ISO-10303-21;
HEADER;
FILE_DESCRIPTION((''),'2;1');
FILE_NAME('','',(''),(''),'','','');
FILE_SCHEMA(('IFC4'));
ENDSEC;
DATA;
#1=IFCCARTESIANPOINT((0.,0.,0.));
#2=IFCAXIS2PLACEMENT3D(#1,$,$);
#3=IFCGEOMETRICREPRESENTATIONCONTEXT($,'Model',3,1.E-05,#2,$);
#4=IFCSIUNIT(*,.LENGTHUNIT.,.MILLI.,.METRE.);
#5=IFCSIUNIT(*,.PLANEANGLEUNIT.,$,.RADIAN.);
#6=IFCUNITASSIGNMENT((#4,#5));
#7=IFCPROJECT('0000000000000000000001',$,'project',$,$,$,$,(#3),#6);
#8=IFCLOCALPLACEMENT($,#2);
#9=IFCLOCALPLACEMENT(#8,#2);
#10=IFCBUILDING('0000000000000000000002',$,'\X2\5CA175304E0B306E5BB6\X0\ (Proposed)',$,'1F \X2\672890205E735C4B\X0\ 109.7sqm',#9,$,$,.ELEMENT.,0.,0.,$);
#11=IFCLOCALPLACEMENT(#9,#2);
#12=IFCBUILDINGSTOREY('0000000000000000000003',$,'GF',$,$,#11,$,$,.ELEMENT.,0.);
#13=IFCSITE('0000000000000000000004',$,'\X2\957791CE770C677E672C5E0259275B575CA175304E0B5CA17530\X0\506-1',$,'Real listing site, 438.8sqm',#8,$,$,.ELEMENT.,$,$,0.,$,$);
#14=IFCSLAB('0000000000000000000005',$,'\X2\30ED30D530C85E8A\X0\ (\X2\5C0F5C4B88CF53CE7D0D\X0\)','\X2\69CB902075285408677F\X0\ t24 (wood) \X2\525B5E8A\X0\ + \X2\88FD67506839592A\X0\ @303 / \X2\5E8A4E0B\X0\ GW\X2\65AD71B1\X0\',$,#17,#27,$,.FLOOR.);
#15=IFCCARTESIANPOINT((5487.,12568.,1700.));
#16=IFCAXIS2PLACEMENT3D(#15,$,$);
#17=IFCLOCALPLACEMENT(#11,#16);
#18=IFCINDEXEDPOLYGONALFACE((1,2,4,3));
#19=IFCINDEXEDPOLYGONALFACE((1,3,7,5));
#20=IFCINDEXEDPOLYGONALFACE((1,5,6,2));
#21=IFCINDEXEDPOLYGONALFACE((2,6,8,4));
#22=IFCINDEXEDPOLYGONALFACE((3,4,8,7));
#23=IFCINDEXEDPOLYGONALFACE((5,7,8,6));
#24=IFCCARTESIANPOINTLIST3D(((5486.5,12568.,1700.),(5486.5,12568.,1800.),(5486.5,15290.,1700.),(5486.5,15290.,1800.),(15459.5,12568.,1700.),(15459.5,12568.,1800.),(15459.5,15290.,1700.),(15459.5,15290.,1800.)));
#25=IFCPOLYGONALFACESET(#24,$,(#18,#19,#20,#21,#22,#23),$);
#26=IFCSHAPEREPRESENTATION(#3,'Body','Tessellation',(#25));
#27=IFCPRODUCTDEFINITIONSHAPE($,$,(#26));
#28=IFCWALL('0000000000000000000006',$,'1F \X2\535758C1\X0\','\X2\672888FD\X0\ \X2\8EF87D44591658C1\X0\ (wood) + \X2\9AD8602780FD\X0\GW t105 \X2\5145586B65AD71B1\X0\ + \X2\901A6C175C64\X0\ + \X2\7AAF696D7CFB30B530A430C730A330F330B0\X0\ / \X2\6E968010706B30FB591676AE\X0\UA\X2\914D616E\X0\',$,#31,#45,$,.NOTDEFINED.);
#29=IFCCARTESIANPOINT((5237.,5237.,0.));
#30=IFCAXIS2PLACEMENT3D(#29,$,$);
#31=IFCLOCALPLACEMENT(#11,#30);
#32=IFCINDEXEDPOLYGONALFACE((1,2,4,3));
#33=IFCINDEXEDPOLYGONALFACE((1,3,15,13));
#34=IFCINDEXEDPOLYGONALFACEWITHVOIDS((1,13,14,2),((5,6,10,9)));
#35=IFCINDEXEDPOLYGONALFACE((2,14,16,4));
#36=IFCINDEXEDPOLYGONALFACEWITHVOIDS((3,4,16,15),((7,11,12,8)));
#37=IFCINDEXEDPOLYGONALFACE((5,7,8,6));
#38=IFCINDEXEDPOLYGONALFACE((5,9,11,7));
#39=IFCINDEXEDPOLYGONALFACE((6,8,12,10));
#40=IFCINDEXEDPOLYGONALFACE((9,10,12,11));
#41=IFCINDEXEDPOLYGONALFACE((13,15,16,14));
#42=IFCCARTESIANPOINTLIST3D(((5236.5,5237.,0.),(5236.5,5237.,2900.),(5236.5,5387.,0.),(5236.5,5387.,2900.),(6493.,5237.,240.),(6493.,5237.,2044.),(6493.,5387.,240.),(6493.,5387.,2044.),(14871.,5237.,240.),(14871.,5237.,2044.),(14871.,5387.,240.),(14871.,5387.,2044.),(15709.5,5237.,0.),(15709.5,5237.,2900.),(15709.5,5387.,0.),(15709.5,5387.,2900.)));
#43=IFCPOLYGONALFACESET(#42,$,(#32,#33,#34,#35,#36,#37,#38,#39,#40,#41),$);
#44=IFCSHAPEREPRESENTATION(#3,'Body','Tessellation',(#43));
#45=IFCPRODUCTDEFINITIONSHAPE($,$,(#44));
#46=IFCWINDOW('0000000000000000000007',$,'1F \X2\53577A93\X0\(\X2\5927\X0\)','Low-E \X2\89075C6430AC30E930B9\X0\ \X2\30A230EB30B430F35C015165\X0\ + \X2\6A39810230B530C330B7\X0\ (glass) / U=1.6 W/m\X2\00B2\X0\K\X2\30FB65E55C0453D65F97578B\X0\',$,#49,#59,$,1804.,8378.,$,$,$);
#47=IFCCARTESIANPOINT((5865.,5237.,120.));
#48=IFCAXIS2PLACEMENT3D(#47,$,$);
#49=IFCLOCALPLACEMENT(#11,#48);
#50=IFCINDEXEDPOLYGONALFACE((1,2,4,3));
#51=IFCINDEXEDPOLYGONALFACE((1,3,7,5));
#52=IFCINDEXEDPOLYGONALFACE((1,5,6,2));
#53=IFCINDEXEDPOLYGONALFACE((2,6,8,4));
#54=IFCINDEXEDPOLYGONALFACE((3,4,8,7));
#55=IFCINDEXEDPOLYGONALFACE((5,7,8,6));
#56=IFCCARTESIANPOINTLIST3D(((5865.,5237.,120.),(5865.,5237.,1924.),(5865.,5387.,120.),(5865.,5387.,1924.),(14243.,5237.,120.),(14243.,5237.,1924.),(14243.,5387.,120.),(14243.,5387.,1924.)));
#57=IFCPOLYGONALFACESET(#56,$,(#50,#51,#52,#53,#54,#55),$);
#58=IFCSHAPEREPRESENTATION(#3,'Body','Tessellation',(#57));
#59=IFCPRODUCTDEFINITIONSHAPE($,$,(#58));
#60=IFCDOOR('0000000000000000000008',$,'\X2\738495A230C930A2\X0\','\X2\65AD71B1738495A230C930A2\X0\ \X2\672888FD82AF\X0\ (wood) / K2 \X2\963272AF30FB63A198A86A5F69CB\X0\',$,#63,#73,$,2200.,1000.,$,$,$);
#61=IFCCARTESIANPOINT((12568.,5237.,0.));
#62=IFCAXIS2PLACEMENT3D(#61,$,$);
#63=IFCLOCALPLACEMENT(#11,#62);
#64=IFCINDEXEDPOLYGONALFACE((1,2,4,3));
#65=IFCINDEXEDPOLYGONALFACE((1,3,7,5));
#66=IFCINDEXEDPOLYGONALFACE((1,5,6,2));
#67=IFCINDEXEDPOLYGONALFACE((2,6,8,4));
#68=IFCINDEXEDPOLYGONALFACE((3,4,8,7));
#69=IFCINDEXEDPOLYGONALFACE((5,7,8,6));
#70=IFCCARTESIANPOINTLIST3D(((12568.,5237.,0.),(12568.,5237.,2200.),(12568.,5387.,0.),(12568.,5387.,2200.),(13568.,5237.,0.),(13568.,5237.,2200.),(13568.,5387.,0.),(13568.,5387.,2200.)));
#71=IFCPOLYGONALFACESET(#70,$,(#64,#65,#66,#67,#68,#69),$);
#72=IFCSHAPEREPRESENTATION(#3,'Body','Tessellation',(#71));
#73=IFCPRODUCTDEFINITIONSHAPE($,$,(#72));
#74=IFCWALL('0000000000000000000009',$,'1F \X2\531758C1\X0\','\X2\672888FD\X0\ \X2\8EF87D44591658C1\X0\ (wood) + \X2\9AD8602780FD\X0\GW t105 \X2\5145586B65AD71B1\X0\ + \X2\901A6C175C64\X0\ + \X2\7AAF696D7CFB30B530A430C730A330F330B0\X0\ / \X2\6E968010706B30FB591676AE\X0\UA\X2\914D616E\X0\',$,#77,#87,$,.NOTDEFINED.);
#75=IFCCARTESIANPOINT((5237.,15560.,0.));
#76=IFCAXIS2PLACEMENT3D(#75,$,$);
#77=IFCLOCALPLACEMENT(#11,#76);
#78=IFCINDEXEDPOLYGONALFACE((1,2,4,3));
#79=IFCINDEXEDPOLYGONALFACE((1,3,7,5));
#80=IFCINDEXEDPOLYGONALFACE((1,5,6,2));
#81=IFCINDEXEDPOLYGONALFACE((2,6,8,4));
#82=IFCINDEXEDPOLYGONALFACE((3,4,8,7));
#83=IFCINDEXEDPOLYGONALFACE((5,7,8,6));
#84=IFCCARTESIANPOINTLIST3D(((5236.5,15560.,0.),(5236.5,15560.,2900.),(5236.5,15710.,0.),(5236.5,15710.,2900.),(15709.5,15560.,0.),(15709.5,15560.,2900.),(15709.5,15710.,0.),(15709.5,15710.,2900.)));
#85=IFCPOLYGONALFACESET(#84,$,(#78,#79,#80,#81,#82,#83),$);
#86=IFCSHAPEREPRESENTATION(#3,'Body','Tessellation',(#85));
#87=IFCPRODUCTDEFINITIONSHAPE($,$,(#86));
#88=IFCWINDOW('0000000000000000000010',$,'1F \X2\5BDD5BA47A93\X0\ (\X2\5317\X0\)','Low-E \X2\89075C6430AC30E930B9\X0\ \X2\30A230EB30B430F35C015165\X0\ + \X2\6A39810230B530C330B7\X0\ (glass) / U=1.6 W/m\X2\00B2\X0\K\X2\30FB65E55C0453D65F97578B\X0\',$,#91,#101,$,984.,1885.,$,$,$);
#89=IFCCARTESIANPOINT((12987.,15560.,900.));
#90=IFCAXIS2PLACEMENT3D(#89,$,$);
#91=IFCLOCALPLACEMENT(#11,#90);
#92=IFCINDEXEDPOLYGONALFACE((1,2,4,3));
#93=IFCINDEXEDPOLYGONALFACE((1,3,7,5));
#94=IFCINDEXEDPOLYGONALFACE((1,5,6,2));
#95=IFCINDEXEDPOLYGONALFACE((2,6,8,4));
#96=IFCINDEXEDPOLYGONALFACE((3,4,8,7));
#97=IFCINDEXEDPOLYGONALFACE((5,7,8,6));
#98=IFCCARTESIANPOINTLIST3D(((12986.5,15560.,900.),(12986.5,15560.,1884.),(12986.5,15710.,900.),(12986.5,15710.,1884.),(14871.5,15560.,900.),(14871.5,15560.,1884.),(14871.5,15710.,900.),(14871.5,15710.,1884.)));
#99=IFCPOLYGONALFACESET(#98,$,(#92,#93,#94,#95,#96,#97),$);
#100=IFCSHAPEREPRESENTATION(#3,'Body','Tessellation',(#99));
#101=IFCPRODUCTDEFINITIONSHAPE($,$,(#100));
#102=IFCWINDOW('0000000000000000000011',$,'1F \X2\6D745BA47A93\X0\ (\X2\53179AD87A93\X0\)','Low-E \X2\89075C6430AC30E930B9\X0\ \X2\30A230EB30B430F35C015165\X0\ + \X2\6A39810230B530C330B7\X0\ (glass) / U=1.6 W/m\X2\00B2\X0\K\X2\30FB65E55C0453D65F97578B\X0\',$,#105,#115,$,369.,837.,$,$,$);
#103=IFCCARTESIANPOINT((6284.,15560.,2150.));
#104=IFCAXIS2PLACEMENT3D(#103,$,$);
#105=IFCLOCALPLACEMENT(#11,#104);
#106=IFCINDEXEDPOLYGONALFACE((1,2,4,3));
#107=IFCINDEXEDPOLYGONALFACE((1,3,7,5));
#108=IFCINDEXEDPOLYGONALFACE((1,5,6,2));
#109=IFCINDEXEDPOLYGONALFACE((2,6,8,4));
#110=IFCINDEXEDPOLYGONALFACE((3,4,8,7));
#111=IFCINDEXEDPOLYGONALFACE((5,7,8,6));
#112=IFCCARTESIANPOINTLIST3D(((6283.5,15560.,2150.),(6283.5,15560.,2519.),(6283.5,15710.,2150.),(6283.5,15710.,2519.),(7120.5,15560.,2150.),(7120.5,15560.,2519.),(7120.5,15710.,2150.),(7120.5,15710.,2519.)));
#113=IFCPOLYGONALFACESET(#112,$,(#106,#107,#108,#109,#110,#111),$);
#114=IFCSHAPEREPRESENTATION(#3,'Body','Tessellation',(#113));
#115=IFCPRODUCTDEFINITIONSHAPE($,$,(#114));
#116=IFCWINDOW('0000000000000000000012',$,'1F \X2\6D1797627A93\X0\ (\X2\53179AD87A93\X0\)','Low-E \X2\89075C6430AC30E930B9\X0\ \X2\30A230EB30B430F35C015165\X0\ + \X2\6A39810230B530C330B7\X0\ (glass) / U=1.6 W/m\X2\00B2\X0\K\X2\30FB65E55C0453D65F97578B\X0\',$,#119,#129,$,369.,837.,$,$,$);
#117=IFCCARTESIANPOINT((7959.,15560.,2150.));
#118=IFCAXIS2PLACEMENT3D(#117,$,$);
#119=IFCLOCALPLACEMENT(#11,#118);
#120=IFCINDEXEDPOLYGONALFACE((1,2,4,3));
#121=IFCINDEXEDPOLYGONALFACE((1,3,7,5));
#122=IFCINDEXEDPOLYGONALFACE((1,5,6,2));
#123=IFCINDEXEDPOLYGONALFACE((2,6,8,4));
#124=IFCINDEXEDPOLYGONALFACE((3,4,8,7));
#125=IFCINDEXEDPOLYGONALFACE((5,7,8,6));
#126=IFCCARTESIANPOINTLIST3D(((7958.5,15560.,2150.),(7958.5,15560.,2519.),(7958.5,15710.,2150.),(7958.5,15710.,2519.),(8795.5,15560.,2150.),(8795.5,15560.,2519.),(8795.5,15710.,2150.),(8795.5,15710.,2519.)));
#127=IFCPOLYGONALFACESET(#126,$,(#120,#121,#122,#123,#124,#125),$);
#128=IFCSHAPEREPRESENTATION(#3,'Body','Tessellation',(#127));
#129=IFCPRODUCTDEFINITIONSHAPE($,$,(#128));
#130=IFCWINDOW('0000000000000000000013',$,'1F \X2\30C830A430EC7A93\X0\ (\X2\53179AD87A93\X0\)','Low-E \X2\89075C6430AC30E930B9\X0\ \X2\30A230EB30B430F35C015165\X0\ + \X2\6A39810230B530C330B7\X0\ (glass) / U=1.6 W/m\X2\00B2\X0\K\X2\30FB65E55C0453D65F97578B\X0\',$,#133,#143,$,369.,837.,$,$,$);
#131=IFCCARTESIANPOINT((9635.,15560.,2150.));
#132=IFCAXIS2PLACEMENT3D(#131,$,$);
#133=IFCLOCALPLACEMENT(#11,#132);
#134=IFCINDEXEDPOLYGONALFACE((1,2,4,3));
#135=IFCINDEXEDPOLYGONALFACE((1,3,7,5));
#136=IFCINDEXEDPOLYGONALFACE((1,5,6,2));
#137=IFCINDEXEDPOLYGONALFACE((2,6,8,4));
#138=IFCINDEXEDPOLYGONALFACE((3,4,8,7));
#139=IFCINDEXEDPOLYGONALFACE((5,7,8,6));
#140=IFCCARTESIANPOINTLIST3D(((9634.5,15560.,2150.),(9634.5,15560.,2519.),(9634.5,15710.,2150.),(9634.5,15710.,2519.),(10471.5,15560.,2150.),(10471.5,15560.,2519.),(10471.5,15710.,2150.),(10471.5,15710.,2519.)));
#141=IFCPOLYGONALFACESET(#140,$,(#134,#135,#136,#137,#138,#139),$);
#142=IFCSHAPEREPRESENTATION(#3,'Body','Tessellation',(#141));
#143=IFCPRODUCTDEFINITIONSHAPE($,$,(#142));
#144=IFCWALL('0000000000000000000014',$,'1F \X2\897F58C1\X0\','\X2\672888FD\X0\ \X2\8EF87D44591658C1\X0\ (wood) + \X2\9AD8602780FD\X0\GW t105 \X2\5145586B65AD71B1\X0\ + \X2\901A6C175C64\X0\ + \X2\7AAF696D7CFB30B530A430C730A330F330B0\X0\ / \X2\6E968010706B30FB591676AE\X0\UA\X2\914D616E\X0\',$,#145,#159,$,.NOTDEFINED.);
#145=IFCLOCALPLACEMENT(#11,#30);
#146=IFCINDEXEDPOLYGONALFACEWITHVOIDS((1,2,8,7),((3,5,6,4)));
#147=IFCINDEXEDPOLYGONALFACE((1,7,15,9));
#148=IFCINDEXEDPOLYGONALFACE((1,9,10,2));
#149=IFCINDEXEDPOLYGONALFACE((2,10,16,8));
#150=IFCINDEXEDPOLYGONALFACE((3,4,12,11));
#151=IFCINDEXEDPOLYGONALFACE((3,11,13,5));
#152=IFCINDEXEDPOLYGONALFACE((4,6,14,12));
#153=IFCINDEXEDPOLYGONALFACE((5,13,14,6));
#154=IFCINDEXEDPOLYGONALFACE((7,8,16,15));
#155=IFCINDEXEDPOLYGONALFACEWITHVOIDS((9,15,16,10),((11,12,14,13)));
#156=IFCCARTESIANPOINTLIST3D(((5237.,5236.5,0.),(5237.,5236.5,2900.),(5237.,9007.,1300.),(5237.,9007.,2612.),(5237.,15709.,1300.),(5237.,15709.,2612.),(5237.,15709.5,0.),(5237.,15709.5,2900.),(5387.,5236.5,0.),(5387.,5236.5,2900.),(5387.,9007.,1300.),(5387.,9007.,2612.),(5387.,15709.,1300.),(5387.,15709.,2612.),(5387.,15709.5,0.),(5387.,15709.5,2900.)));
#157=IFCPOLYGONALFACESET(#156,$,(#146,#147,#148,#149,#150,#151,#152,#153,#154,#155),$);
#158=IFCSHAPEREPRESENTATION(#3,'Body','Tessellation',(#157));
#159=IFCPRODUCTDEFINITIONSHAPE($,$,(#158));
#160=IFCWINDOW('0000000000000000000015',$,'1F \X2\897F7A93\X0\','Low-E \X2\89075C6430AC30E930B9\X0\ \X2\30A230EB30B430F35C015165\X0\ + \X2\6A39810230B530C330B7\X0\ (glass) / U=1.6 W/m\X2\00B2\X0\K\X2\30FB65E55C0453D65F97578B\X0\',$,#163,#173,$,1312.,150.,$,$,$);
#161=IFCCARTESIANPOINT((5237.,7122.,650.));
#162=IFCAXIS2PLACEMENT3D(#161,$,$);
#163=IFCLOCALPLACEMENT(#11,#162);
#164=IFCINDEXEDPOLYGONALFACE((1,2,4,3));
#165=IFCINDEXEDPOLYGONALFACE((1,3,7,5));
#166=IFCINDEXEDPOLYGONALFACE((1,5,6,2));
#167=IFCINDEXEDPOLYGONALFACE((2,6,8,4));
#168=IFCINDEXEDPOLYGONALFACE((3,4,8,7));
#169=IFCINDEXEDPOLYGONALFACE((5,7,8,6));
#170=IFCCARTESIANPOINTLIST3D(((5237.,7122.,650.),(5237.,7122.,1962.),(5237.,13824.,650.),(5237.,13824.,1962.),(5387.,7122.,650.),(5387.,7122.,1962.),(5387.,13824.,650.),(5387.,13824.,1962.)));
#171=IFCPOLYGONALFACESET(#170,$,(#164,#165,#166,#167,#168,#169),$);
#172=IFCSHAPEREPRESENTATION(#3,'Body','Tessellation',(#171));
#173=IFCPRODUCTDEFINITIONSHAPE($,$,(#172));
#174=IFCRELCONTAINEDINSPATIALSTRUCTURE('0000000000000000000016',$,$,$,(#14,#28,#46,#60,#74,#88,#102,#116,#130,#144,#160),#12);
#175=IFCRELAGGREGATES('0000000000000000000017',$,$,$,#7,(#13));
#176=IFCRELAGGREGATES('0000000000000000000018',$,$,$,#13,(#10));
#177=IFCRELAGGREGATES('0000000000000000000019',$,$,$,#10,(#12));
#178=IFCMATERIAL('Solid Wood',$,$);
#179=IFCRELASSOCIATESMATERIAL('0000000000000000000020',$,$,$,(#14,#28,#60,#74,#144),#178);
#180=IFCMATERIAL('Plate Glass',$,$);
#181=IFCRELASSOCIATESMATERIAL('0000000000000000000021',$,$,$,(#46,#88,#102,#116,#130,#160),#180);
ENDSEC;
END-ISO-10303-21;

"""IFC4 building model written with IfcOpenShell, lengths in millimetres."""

from ifc_helpers import new_model, si_unit, frame, frame_2d, origin, place, context, project, spatial, rectangle, extrude, material, element, fill, save


model = new_model("IFC4")

# Units and contexts
model_context = context("Model", 3, precision=1e-05, world=origin())
ifc_project = project(units=[si_unit("LENGTHUNIT", "METRE", prefix="MILLI"), si_unit("PLANEANGLEUNIT", "RADIAN")], contexts=[model_context])

# Site, building, storey
site_placement = place(None, origin())
site = spatial("IfcSite", under=ifc_project, at=site_placement, Name="長野県松本市大字岡田下岡田506-1", ObjectType="Real listing site, 438.8sqm", CompositionType="ELEMENT", RefElevation=0.0)
building_placement = place(site_placement, origin())
building = spatial("IfcBuilding", under=site, at=building_placement, Name="岡田下の家 (Proposed)", ObjectType="1F 木造平屋 109.7sqm", CompositionType="ELEMENT", ElevationOfRefHeight=0.0, ElevationOfTerrain=0.0)
storey_placement = place(building_placement, origin())
storey = spatial("IfcBuildingStorey", under=building, at=storey_placement, Name="GF", CompositionType="ELEMENT", Elevation=0.0)

# Slab
ifc_material_1 = material(Name="Solid Wood")
slab_1_placement = place(storey_placement, frame((5487.0, 12568.0, 1700.0)))
element("IfcSlab", 1, at=slab_1_placement, inside=storey, material=ifc_material_1, Name="ロフト床 (小屋裏収納)", Description="構造用合板 t24 (wood) 剛床 + 製材根太 @303 / 床下 GW断熱", PredefinedType="FLOOR", context=model_context, shape_type="SweptSolid", body=[
    extrude(rectangle(XDim=9973.0, YDim=2722.0, at=frame_2d((4986.0, 1361.0))), frame((5487.0, 12568.0, 1700.0)), (0.0, 0.0, 1.0), 100.0),
])

# Wall, openings, window, door
wall_1_placement = place(storey_placement, frame((5237.0, 5237.0, 0.0)))
wall_1 = element("IfcWall", 2, at=wall_1_placement, inside=storey, material=ifc_material_1, Name="1F 南壁", Description="木製 軸組外壁 (wood) + 高性能GW t105 充填断熱 + 通気層 + 窯業系サイディング / 準耐火・外皮UA配慮", PredefinedType="NOTDEFINED", context=model_context, shape_type="SweptSolid", body=[
    extrude(rectangle(XDim=10473.0, YDim=150.0, at=frame_2d((5236.0, 75.0))), frame((5237.0, 5237.0, 0.0)), (0.0, 0.0, 1.0), 2900.0),
])
opening_1_placement = place(storey_placement, frame((5865.0, 5237.0, 120.0)))
opening_1 = element("IfcOpeningElement", 3, at=opening_1_placement, cuts=wall_1, PredefinedType="NOTDEFINED", context=model_context, shape_type="SweptSolid", body=[
    extrude(rectangle(XDim=8378.0, YDim=150.0, at=frame_2d((4189.0, 75.0))), frame((5865.0, 5237.0, 120.0)), (0.0, 0.0, 1.0), 1804.0),
])
opening_2_placement = place(storey_placement, frame((12568.0, 5237.0, 0.0)))
opening_2 = element("IfcOpeningElement", 4, at=opening_2_placement, cuts=wall_1, PredefinedType="NOTDEFINED", context=model_context, shape_type="SweptSolid", body=[
    extrude(rectangle(XDim=1000.0, YDim=150.0, at=frame_2d((500.0, 75.0))), frame((12568.0, 5237.0, 0.0)), (0.0, 0.0, 1.0), 2200.0),
])
ifc_material_2 = material(Name="Plate Glass")
window_1_placement = place(storey_placement, frame((5865.0, 5237.0, 120.0)))
window_1 = element("IfcWindow", 5, at=window_1_placement, inside=storey, material=ifc_material_2, Name="1F 南窓(大)", Description="Low-E 複層ガラス アルゴン封入 + 樹脂サッシ (glass) / U=1.6 W/m²K・日射取得型", OverallHeight=1804.0, OverallWidth=8378.0, context=model_context, shape_type="SweptSolid", body=[
    extrude(rectangle(XDim=8378.0, YDim=150.0, at=frame_2d((4189.0, 75.0))), frame((5865.0, 5237.0, 120.0)), (0.0, 0.0, 1.0), 1804.0),
])
fill(opening_1, window_1)
door_1_placement = place(storey_placement, frame((12568.0, 5237.0, 0.0)))
door_1 = element("IfcDoor", 6, at=door_1_placement, inside=storey, material=ifc_material_1, Name="玄関ドア", Description="断熱玄関ドア 木製芯 (wood) / K2 防犯・採風機構", OverallHeight=2200.0, OverallWidth=1000.0, context=model_context, shape_type="SweptSolid", body=[
    extrude(rectangle(XDim=1000.0, YDim=150.0, at=frame_2d((500.0, 75.0))), frame((12568.0, 5237.0, 0.0)), (0.0, 0.0, 1.0), 2200.0),
])
fill(opening_2, door_1)

# Wall, openings, windows
wall_2_placement = place(storey_placement, frame((5237.0, 15560.0, 0.0)))
wall_2 = element("IfcWall", 7, at=wall_2_placement, inside=storey, material=ifc_material_1, Name="1F 北壁", Description="木製 軸組外壁 (wood) + 高性能GW t105 充填断熱 + 通気層 + 窯業系サイディング / 準耐火・外皮UA配慮", PredefinedType="NOTDEFINED", context=model_context, shape_type="SweptSolid", body=[
    extrude(rectangle(XDim=10473.0, YDim=150.0, at=frame_2d((5236.0, 75.0))), frame((5237.0, 15560.0, 0.0)), (0.0, 0.0, 1.0), 2900.0),
])
opening_3_placement = place(storey_placement, frame((12987.0, 15560.0, 900.0)))
opening_3 = element("IfcOpeningElement", 8, at=opening_3_placement, cuts=wall_2, PredefinedType="NOTDEFINED", context=model_context, shape_type="SweptSolid", body=[
    extrude(rectangle(XDim=1885.0, YDim=150.0, at=frame_2d((942.0, 75.0))), frame((12987.0, 15560.0, 900.0)), (0.0, 0.0, 1.0), 984.0),
])
opening_4_placement = place(storey_placement, frame((6284.0, 15560.0, 2150.0)))
opening_4 = element("IfcOpeningElement", 9, at=opening_4_placement, cuts=wall_2, PredefinedType="NOTDEFINED", context=model_context, shape_type="SweptSolid", body=[
    extrude(rectangle(XDim=837.0, YDim=150.0, at=frame_2d((418.0, 75.0))), frame((6284.0, 15560.0, 2150.0)), (0.0, 0.0, 1.0), 369.0),
])
opening_5_placement = place(storey_placement, frame((7959.0, 15560.0, 2150.0)))
opening_5 = element("IfcOpeningElement", 10, at=opening_5_placement, cuts=wall_2, PredefinedType="NOTDEFINED", context=model_context, shape_type="SweptSolid", body=[
    extrude(rectangle(XDim=837.0, YDim=150.0, at=frame_2d((418.0, 75.0))), frame((7959.0, 15560.0, 2150.0)), (0.0, 0.0, 1.0), 369.0),
])
opening_6_placement = place(storey_placement, frame((9635.0, 15560.0, 2150.0)))
opening_6 = element("IfcOpeningElement", 11, at=opening_6_placement, cuts=wall_2, PredefinedType="NOTDEFINED", context=model_context, shape_type="SweptSolid", body=[
    extrude(rectangle(XDim=837.0, YDim=150.0, at=frame_2d((418.0, 75.0))), frame((9635.0, 15560.0, 2150.0)), (0.0, 0.0, 1.0), 369.0),
])
window_2_placement = place(storey_placement, frame((12987.0, 15560.0, 900.0)))
window_2 = element("IfcWindow", 12, at=window_2_placement, inside=storey, material=ifc_material_2, Name="1F 寝室窓 (北)", Description="Low-E 複層ガラス アルゴン封入 + 樹脂サッシ (glass) / U=1.6 W/m²K・日射取得型", OverallHeight=984.0, OverallWidth=1885.0, context=model_context, shape_type="SweptSolid", body=[
    extrude(rectangle(XDim=1885.0, YDim=150.0, at=frame_2d((942.0, 75.0))), frame((12987.0, 15560.0, 900.0)), (0.0, 0.0, 1.0), 984.0),
])
fill(opening_3, window_2)
window_3_placement = place(storey_placement, frame((6284.0, 15560.0, 2150.0)))
window_3 = element("IfcWindow", 13, at=window_3_placement, inside=storey, material=ifc_material_2, Name="1F 浴室窓 (北高窓)", Description="Low-E 複層ガラス アルゴン封入 + 樹脂サッシ (glass) / U=1.6 W/m²K・日射取得型", OverallHeight=369.0, OverallWidth=837.0, context=model_context, shape_type="SweptSolid", body=[
    extrude(rectangle(XDim=837.0, YDim=150.0, at=frame_2d((418.0, 75.0))), frame((6284.0, 15560.0, 2150.0)), (0.0, 0.0, 1.0), 369.0),
])
fill(opening_4, window_3)
window_4_placement = place(storey_placement, frame((7959.0, 15560.0, 2150.0)))
window_4 = element("IfcWindow", 14, at=window_4_placement, inside=storey, material=ifc_material_2, Name="1F 洗面窓 (北高窓)", Description="Low-E 複層ガラス アルゴン封入 + 樹脂サッシ (glass) / U=1.6 W/m²K・日射取得型", OverallHeight=369.0, OverallWidth=837.0, context=model_context, shape_type="SweptSolid", body=[
    extrude(rectangle(XDim=837.0, YDim=150.0, at=frame_2d((418.0, 75.0))), frame((7959.0, 15560.0, 2150.0)), (0.0, 0.0, 1.0), 369.0),
])
fill(opening_5, window_4)
window_5_placement = place(storey_placement, frame((9635.0, 15560.0, 2150.0)))
window_5 = element("IfcWindow", 15, at=window_5_placement, inside=storey, material=ifc_material_2, Name="1F トイレ窓 (北高窓)", Description="Low-E 複層ガラス アルゴン封入 + 樹脂サッシ (glass) / U=1.6 W/m²K・日射取得型", OverallHeight=369.0, OverallWidth=837.0, context=model_context, shape_type="SweptSolid", body=[
    extrude(rectangle(XDim=837.0, YDim=150.0, at=frame_2d((418.0, 75.0))), frame((9635.0, 15560.0, 2150.0)), (0.0, 0.0, 1.0), 369.0),
])
fill(opening_6, window_5)

# Wall, opening, window
wall_3_placement = place(storey_placement, frame((5237.0, 5237.0, 0.0)))
wall_3 = element("IfcWall", 16, at=wall_3_placement, inside=storey, material=ifc_material_1, Name="1F 西壁", Description="木製 軸組外壁 (wood) + 高性能GW t105 充填断熱 + 通気層 + 窯業系サイディング / 準耐火・外皮UA配慮", PredefinedType="NOTDEFINED", context=model_context, shape_type="SweptSolid", body=[
    extrude(rectangle(XDim=150.0, YDim=10473.0, at=frame_2d((75.0, 5236.0))), frame((5237.0, 5237.0, 0.0)), (0.0, 0.0, 1.0), 2900.0),
])
opening_7_placement = place(storey_placement, frame((5237.0, 7122.0, 650.0)))
opening_7 = element("IfcOpeningElement", 17, at=opening_7_placement, cuts=wall_3, PredefinedType="NOTDEFINED", context=model_context, shape_type="SweptSolid", body=[
    extrude(rectangle(XDim=150.0, YDim=6702.0, at=frame_2d((75.0, 3351.0))), frame((5237.0, 7122.0, 650.0)), (0.0, 0.0, 1.0), 1312.0),
])
window_6_placement = place(storey_placement, frame((5237.0, 7122.0, 650.0)))
window_6 = element("IfcWindow", 18, at=window_6_placement, inside=storey, material=ifc_material_2, Name="1F 西窓", Description="Low-E 複層ガラス アルゴン封入 + 樹脂サッシ (glass) / U=1.6 W/m²K・日射取得型", OverallHeight=1312.0, OverallWidth=150.0, context=model_context, shape_type="SweptSolid", body=[
    extrude(rectangle(XDim=150.0, YDim=6702.0, at=frame_2d((75.0, 3351.0))), frame((5237.0, 7122.0, 650.0)), (0.0, 0.0, 1.0), 1312.0),
])
fill(opening_7, window_6)

save(model, "model.ifc")
